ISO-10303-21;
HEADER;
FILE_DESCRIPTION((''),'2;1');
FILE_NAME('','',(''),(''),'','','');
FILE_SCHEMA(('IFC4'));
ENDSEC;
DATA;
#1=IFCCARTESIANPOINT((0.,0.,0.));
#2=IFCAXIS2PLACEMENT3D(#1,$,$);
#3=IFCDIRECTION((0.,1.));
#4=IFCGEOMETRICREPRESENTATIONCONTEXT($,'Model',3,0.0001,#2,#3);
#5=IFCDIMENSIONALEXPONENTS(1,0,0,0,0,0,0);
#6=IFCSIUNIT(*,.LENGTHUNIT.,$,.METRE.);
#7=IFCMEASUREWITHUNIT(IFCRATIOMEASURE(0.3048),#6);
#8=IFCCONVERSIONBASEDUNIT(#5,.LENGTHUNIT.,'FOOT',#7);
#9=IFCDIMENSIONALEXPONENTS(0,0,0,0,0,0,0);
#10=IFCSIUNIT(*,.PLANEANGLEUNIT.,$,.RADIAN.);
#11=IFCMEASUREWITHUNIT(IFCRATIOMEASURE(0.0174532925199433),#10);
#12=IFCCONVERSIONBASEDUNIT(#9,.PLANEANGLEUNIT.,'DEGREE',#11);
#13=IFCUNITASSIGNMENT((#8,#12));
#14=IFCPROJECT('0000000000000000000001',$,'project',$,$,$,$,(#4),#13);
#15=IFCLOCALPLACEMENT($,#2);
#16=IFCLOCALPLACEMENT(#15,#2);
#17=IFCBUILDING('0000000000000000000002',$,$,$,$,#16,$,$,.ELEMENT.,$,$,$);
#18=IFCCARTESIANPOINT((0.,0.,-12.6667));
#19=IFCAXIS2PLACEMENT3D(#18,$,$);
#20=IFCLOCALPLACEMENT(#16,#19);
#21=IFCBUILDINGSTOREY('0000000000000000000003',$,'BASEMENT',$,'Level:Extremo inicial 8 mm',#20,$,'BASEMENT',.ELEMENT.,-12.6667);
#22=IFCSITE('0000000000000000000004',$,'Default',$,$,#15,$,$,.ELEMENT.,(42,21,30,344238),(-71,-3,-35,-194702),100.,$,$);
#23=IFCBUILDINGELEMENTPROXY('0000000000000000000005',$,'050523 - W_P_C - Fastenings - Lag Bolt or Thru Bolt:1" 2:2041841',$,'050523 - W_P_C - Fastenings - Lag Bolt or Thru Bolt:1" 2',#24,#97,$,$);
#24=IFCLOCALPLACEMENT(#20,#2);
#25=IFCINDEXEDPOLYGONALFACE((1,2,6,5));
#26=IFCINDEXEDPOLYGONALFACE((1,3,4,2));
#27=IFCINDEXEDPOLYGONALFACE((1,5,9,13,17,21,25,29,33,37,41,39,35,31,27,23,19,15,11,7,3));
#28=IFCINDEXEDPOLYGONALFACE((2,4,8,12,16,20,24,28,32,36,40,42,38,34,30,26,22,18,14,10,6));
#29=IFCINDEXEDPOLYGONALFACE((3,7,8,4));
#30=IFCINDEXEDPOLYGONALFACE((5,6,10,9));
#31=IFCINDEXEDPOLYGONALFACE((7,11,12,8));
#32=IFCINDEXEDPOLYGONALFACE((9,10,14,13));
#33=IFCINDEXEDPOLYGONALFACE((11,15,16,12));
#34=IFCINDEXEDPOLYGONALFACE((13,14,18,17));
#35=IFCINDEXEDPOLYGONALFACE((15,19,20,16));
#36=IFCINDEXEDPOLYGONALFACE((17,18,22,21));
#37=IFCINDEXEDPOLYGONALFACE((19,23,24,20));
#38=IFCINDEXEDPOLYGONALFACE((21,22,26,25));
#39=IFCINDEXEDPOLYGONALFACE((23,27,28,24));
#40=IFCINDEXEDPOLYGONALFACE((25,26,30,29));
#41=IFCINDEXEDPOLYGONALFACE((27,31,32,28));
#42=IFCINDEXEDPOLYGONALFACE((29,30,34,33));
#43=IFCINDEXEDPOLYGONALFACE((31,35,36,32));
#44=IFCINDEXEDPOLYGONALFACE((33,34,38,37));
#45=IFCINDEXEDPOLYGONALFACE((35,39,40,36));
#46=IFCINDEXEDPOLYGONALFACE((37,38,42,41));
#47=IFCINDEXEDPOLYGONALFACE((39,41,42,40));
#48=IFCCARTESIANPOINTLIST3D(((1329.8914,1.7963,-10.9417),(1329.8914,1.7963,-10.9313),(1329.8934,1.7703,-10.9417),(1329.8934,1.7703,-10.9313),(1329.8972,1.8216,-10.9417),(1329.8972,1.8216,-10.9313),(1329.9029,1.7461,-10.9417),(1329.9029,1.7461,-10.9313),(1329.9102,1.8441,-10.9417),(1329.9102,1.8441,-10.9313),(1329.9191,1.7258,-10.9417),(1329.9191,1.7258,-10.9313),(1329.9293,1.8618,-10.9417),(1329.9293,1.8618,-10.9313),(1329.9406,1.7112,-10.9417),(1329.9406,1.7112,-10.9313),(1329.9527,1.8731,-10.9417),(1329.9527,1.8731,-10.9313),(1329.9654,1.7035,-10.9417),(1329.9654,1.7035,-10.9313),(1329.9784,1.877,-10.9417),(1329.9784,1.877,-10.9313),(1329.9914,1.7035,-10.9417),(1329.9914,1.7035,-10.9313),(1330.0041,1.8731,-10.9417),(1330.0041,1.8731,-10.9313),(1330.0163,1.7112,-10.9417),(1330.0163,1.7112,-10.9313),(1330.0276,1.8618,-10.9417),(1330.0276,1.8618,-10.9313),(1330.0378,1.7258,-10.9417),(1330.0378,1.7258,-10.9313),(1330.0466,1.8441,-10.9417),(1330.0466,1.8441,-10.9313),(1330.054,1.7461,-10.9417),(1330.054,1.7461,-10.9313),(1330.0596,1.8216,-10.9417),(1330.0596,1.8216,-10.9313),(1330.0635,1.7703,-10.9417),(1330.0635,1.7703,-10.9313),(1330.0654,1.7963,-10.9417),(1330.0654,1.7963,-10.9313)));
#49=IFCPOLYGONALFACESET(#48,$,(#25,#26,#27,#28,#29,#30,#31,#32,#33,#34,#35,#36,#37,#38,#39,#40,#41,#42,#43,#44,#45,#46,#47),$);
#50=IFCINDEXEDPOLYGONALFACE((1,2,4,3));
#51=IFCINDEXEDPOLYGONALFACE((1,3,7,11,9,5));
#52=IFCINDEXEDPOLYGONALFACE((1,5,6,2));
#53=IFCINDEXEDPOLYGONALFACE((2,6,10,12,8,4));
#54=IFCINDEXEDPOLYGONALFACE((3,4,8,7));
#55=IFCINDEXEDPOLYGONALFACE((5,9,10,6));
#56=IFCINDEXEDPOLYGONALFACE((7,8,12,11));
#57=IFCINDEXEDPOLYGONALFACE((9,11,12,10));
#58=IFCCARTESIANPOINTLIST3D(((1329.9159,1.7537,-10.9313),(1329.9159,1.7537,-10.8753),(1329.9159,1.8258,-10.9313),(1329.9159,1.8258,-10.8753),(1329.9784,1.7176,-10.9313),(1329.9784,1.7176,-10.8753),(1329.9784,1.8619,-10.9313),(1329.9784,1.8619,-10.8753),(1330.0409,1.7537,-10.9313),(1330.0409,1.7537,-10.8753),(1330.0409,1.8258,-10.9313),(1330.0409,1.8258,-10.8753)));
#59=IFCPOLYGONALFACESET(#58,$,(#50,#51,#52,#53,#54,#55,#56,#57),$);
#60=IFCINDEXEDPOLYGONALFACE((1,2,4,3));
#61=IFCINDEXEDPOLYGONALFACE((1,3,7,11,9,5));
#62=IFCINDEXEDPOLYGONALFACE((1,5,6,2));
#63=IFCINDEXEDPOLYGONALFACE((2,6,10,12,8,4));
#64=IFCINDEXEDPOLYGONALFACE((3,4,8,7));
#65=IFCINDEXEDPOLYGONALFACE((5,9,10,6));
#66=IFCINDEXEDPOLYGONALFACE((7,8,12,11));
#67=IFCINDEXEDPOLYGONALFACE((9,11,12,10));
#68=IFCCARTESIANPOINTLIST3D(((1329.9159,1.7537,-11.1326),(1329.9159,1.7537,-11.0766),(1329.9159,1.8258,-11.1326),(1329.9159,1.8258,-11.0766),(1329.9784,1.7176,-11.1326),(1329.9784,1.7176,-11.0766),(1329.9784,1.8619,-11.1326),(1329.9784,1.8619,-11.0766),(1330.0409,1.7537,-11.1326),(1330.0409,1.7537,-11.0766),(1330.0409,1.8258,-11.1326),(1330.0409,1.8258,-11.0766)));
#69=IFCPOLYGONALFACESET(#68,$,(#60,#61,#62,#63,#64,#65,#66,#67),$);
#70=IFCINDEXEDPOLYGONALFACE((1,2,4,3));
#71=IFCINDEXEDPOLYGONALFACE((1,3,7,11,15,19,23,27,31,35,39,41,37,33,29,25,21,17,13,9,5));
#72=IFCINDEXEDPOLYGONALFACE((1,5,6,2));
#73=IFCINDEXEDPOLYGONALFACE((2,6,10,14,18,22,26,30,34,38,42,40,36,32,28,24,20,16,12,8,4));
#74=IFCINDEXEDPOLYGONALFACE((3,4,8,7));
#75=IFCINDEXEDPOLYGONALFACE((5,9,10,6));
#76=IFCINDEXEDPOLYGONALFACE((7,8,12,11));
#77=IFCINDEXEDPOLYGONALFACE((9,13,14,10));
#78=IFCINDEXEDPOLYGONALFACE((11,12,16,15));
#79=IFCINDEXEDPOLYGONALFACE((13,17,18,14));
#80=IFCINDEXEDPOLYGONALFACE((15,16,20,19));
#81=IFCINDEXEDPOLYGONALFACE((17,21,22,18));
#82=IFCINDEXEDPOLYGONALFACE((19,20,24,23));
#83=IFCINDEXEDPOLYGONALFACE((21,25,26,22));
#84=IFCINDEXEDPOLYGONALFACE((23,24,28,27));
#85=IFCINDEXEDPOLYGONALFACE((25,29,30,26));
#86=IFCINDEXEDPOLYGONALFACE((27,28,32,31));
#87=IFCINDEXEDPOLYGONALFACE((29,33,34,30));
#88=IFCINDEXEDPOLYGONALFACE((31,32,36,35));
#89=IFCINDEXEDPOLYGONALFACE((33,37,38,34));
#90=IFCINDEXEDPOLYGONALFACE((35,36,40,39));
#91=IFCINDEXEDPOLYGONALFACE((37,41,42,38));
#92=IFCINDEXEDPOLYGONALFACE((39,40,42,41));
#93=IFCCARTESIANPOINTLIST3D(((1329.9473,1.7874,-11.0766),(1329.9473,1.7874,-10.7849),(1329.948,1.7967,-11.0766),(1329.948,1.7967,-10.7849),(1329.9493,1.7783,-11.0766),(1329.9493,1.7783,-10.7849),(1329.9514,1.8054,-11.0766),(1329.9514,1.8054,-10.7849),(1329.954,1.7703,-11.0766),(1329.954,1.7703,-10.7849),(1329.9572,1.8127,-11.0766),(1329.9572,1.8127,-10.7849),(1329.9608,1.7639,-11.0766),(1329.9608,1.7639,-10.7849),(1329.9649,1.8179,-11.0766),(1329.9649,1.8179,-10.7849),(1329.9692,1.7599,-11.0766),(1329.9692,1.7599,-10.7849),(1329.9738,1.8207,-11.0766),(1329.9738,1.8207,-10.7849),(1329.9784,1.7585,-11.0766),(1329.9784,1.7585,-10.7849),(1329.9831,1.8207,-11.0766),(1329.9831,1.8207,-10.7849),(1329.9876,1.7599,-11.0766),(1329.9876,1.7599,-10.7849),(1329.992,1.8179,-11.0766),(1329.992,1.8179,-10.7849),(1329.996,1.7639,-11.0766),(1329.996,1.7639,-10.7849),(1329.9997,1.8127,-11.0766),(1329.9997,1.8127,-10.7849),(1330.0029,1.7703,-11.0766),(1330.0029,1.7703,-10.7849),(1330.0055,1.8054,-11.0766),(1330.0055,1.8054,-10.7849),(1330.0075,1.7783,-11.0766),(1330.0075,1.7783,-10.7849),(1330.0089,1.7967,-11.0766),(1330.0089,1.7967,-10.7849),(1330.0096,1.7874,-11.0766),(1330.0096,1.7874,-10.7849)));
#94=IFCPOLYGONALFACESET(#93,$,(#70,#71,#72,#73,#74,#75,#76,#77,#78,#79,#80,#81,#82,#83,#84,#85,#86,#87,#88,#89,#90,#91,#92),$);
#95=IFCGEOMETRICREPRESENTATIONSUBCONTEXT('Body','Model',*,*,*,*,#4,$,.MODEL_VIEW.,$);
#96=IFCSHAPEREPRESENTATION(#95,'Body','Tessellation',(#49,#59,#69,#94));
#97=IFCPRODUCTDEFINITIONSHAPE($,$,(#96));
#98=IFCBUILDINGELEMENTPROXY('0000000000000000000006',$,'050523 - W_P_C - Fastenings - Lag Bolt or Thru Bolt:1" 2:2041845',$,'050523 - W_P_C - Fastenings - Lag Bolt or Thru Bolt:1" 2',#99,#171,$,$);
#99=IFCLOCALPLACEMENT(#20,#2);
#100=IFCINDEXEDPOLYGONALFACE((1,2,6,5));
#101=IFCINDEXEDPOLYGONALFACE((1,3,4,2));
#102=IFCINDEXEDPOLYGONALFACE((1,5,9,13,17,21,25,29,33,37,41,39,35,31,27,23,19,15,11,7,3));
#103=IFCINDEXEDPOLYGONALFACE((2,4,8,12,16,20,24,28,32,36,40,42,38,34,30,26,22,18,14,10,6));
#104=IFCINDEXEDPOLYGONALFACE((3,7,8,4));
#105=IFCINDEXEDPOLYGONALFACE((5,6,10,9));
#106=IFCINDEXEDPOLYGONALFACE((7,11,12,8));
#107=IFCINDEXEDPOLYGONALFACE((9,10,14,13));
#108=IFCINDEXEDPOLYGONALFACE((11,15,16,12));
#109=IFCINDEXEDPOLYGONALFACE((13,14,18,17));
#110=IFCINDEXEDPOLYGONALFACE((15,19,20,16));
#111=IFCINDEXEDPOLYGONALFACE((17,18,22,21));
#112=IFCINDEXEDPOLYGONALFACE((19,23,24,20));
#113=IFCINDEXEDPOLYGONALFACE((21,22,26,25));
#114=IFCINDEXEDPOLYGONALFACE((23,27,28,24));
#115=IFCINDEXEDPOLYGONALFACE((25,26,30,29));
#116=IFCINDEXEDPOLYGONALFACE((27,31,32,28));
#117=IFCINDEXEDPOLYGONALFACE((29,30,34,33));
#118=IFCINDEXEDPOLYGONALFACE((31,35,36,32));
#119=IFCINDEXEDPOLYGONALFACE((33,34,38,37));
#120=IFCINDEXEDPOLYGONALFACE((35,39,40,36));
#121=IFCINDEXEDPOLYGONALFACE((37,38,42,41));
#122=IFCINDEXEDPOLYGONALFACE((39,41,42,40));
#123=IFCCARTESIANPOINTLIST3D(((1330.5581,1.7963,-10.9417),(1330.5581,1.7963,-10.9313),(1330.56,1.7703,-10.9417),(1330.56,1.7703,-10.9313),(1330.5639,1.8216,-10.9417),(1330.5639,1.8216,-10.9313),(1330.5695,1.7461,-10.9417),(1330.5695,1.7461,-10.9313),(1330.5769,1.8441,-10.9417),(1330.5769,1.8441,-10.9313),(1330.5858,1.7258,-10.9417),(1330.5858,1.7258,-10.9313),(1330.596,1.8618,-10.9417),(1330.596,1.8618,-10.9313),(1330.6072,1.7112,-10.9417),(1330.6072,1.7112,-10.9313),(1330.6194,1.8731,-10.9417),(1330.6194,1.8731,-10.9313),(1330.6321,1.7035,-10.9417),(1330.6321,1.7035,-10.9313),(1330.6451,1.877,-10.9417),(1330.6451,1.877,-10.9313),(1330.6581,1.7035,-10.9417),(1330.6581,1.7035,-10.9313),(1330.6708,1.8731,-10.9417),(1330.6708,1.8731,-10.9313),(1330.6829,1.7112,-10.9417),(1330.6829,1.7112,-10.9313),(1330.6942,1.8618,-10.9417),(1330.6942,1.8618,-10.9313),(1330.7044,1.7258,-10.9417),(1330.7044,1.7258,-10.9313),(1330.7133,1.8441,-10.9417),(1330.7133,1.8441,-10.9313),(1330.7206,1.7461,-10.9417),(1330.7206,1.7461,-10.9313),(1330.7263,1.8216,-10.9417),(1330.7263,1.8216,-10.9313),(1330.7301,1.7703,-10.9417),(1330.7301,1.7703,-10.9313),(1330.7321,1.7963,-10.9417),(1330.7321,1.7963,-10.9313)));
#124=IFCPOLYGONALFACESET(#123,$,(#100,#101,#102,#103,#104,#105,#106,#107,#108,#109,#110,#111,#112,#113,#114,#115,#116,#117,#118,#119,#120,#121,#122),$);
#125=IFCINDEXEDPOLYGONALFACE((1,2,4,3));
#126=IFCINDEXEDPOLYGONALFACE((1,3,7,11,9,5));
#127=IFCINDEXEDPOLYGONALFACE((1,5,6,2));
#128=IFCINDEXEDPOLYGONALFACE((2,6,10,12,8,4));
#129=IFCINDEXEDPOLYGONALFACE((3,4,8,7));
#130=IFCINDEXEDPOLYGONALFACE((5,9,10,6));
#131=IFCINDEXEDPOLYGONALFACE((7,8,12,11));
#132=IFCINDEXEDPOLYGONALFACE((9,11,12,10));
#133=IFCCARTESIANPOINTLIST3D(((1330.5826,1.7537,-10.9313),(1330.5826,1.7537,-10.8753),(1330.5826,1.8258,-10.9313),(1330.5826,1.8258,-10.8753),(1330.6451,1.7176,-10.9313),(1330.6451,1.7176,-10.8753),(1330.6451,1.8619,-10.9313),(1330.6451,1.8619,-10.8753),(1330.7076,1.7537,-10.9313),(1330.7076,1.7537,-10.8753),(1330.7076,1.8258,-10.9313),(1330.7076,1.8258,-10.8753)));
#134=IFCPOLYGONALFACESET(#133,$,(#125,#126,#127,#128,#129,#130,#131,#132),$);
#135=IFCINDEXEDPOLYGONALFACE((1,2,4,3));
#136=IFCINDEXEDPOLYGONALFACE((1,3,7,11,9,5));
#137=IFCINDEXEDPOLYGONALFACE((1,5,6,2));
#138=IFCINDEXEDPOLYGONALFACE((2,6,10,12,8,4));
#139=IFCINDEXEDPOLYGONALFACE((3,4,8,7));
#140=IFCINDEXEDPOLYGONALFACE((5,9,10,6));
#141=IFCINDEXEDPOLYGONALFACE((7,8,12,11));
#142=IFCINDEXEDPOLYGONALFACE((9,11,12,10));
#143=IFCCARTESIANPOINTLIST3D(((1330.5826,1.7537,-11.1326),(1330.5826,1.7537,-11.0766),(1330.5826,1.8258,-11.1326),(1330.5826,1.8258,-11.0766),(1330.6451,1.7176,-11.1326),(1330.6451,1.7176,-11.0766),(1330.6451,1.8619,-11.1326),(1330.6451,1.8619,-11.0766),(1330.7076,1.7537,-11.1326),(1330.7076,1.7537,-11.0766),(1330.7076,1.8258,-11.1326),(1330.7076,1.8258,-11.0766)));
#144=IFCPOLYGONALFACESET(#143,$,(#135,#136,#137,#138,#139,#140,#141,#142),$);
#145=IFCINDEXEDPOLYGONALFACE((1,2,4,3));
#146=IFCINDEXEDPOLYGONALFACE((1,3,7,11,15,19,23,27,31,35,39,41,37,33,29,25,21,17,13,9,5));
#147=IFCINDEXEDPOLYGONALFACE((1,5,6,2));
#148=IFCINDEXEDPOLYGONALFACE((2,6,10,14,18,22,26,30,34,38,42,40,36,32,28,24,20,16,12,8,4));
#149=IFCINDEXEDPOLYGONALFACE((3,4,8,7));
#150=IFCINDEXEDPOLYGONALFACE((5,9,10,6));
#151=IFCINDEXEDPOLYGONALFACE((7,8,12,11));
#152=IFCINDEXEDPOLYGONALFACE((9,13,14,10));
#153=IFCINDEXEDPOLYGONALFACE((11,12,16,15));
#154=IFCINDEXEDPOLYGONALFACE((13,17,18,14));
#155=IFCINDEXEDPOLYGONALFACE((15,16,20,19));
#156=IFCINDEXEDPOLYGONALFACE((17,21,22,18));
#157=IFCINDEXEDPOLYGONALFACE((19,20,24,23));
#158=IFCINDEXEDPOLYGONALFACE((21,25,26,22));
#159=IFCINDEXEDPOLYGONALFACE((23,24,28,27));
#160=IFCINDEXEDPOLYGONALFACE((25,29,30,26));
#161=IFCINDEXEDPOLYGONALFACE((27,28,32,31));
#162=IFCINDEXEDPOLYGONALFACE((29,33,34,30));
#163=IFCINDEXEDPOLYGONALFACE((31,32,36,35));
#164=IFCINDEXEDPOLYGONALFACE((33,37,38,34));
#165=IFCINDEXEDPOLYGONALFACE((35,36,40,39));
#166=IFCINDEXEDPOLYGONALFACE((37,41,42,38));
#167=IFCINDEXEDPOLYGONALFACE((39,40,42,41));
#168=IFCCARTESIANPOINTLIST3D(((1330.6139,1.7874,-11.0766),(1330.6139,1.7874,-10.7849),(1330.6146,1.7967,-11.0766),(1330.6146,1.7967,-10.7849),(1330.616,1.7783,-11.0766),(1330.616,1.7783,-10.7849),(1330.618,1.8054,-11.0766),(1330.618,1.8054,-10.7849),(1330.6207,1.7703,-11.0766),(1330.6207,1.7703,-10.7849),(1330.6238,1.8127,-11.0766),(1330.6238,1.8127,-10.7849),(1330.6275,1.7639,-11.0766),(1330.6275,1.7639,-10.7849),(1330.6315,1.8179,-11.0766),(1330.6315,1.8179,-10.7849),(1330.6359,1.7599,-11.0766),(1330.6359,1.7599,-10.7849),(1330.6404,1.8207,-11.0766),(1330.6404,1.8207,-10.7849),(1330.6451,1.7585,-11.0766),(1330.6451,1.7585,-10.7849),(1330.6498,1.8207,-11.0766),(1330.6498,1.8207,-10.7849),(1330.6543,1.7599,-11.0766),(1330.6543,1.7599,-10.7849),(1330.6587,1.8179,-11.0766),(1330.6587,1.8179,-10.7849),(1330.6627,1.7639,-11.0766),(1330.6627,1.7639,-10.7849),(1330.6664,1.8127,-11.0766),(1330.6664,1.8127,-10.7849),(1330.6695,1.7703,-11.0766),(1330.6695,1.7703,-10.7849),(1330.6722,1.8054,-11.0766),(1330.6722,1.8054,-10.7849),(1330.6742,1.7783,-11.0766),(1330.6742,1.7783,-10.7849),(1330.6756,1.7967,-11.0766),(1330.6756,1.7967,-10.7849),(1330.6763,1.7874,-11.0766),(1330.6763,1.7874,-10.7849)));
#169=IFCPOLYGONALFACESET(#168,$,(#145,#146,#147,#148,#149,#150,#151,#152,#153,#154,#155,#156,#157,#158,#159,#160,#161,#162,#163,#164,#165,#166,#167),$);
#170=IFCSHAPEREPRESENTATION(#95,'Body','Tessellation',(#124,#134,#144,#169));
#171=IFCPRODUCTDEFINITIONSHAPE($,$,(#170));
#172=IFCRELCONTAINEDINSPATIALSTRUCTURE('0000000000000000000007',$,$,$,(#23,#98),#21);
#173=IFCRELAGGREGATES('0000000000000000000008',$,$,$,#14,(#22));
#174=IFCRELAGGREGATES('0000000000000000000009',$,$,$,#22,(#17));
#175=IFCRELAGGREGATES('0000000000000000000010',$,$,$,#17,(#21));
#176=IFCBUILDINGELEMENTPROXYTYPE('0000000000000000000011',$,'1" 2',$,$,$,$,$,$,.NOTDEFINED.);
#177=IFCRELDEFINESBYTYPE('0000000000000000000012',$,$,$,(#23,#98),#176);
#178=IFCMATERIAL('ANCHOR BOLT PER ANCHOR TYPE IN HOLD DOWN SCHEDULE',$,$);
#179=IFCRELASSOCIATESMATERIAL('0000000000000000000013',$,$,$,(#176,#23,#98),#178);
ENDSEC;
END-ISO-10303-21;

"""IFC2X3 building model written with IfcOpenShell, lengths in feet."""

from ifc_helpers import new_model, entity, si_unit, converted_unit, direction, frame, frame_2d, origin, place, context, subcontext, project, spatial, polyline, circle, outline, extrude, source, transform, mapped, material, type_object, type_shapes, element, save


model = new_model("IFC2X3")

# Units and contexts
model_context = context("Model", 3, precision=0.0001, world=origin(), true_north=direction((0.0, 1.0)))
body_context = subcontext(model_context, "Body", "Model", "MODEL_VIEW")
ifc_project = project(units=[converted_unit("LENGTHUNIT", "FOOT", entity("IfcRatioMeasure", 0.3048), si_unit("LENGTHUNIT", "METRE"), dimensions=[1, 0, 0, 0, 0, 0, 0]), converted_unit("PLANEANGLEUNIT", "DEGREE", entity("IfcRatioMeasure", 0.0174532925199433), si_unit("PLANEANGLEUNIT", "RADIAN"), dimensions=[0, 0, 0, 0, 0, 0, 0])], contexts=[model_context])

# Site, building, storey
site_placement = place(None, origin())
site = spatial("IfcSite", under=ifc_project, at=site_placement, Name="Default", CompositionType="ELEMENT", RefLatitude=(42, 21, 30, 344238), RefLongitude=(-71, -3, -35, -194702), RefElevation=100.0)
building_placement = place(site_placement, origin())
building = spatial("IfcBuilding", under=site, at=building_placement, CompositionType="ELEMENT")
storey_placement = place(building_placement, frame((0.0, 0.0, -12.6667)))
storey = spatial("IfcBuildingStorey", under=building, at=storey_placement, Name="BASEMENT", ObjectType="Level:Extremo inicial 8 mm", LongName="BASEMENT", CompositionType="ELEMENT", Elevation=-12.6667)

# Building element proxies
ifc_material_1 = material(Name="ANCHOR BOLT PER ANCHOR TYPE IN HOLD DOWN SCHEDULE")
building_element_proxy_type_1 = type_object("IfcBuildingElementProxyType", Name="1\" 2", PredefinedType="NOTDEFINED", material=ifc_material_1)
shared_shape_1 = source(origin(), body_context, "Body", "SweptSolid", [
    extrude(circle(Radius=0.0872, at=frame_2d((0.0, 0.0), x_axis=(1.0, 0.0))), frame((0.0, 0.0, -0.1453), z_axis=(0.0, 0.0, 1.0), x_axis=(0.0, -1.0, 0.0)), (0.0, 0.0, 1.0), 0.0104),
    extrude(outline(polyline([(-0.0361, -0.0625), (0.0361, -0.0625), (0.0722, 0.0), (0.0361, 0.0625), (-0.0361, 0.0625), (-0.0722, 0.0), (-0.0361, -0.0625)])), frame((0.0, 0.0, -0.2013), z_axis=(0.0, 0.0, 1.0), x_axis=(0.866025, -0.5, 0.0)), (0.0, 0.0, 1.0), 0.056),
    extrude(outline(polyline([(-0.0361, -0.0625), (0.0361, -0.0625), (0.0722, 0.0), (0.0361, 0.0625), (-0.0361, 0.0625), (-0.0722, 0.0), (-0.0361, -0.0625)])), frame((0.0, 0.0, 0.0), z_axis=(0.0, 0.0, 1.0), x_axis=(0.0, -1.0, 0.0)), (0.0, 0.0, 1.0), 0.056),
    extrude(circle(Radius=0.0312, at=frame_2d((0.0, 0.0), x_axis=(1.0, 0.0))), frame((0.0, 0.0, -0.2917), z_axis=(0.0, 0.0, 1.0), x_axis=(0.0, 1.0, 0.0)), (0.0, 0.0, 1.0), 0.2917),
])
type_shapes(building_element_proxy_type_1, [shared_shape_1])
for number, where, z_axis, x_axis, name in (
    (1, (1329.9784, 1.7898, -11.0766), (0.0, 0.0, -1.0), (1.0, 0.0, 0.0), "050523 - W_P_C - Fastenings - Lag Bolt or Thru Bolt:1\" 2:2041841"),
    (2, (1330.6451, 1.7898, -11.0766), (0.0, 0.0, -1.0), (1.0, 0.0, 0.0), "050523 - W_P_C - Fastenings - Lag Bolt or Thru Bolt:1\" 2:2041845"),
):
    element("IfcBuildingElementProxy", number, at=place(storey_placement, frame(where, z_axis=z_axis, x_axis=x_axis)), inside=storey, type_object=building_element_proxy_type_1, material=ifc_material_1, Name=name, ObjectType="050523 - W_P_C - Fastenings - Lag Bolt or Thru Bolt:1\" 2", context=body_context, shape_type="MappedRepresentation", body=[
        mapped(shared_shape_1, transform((0.0, 0.0, 0.0), scale=1.0)),
    ])

save(model, "model.ifc")
